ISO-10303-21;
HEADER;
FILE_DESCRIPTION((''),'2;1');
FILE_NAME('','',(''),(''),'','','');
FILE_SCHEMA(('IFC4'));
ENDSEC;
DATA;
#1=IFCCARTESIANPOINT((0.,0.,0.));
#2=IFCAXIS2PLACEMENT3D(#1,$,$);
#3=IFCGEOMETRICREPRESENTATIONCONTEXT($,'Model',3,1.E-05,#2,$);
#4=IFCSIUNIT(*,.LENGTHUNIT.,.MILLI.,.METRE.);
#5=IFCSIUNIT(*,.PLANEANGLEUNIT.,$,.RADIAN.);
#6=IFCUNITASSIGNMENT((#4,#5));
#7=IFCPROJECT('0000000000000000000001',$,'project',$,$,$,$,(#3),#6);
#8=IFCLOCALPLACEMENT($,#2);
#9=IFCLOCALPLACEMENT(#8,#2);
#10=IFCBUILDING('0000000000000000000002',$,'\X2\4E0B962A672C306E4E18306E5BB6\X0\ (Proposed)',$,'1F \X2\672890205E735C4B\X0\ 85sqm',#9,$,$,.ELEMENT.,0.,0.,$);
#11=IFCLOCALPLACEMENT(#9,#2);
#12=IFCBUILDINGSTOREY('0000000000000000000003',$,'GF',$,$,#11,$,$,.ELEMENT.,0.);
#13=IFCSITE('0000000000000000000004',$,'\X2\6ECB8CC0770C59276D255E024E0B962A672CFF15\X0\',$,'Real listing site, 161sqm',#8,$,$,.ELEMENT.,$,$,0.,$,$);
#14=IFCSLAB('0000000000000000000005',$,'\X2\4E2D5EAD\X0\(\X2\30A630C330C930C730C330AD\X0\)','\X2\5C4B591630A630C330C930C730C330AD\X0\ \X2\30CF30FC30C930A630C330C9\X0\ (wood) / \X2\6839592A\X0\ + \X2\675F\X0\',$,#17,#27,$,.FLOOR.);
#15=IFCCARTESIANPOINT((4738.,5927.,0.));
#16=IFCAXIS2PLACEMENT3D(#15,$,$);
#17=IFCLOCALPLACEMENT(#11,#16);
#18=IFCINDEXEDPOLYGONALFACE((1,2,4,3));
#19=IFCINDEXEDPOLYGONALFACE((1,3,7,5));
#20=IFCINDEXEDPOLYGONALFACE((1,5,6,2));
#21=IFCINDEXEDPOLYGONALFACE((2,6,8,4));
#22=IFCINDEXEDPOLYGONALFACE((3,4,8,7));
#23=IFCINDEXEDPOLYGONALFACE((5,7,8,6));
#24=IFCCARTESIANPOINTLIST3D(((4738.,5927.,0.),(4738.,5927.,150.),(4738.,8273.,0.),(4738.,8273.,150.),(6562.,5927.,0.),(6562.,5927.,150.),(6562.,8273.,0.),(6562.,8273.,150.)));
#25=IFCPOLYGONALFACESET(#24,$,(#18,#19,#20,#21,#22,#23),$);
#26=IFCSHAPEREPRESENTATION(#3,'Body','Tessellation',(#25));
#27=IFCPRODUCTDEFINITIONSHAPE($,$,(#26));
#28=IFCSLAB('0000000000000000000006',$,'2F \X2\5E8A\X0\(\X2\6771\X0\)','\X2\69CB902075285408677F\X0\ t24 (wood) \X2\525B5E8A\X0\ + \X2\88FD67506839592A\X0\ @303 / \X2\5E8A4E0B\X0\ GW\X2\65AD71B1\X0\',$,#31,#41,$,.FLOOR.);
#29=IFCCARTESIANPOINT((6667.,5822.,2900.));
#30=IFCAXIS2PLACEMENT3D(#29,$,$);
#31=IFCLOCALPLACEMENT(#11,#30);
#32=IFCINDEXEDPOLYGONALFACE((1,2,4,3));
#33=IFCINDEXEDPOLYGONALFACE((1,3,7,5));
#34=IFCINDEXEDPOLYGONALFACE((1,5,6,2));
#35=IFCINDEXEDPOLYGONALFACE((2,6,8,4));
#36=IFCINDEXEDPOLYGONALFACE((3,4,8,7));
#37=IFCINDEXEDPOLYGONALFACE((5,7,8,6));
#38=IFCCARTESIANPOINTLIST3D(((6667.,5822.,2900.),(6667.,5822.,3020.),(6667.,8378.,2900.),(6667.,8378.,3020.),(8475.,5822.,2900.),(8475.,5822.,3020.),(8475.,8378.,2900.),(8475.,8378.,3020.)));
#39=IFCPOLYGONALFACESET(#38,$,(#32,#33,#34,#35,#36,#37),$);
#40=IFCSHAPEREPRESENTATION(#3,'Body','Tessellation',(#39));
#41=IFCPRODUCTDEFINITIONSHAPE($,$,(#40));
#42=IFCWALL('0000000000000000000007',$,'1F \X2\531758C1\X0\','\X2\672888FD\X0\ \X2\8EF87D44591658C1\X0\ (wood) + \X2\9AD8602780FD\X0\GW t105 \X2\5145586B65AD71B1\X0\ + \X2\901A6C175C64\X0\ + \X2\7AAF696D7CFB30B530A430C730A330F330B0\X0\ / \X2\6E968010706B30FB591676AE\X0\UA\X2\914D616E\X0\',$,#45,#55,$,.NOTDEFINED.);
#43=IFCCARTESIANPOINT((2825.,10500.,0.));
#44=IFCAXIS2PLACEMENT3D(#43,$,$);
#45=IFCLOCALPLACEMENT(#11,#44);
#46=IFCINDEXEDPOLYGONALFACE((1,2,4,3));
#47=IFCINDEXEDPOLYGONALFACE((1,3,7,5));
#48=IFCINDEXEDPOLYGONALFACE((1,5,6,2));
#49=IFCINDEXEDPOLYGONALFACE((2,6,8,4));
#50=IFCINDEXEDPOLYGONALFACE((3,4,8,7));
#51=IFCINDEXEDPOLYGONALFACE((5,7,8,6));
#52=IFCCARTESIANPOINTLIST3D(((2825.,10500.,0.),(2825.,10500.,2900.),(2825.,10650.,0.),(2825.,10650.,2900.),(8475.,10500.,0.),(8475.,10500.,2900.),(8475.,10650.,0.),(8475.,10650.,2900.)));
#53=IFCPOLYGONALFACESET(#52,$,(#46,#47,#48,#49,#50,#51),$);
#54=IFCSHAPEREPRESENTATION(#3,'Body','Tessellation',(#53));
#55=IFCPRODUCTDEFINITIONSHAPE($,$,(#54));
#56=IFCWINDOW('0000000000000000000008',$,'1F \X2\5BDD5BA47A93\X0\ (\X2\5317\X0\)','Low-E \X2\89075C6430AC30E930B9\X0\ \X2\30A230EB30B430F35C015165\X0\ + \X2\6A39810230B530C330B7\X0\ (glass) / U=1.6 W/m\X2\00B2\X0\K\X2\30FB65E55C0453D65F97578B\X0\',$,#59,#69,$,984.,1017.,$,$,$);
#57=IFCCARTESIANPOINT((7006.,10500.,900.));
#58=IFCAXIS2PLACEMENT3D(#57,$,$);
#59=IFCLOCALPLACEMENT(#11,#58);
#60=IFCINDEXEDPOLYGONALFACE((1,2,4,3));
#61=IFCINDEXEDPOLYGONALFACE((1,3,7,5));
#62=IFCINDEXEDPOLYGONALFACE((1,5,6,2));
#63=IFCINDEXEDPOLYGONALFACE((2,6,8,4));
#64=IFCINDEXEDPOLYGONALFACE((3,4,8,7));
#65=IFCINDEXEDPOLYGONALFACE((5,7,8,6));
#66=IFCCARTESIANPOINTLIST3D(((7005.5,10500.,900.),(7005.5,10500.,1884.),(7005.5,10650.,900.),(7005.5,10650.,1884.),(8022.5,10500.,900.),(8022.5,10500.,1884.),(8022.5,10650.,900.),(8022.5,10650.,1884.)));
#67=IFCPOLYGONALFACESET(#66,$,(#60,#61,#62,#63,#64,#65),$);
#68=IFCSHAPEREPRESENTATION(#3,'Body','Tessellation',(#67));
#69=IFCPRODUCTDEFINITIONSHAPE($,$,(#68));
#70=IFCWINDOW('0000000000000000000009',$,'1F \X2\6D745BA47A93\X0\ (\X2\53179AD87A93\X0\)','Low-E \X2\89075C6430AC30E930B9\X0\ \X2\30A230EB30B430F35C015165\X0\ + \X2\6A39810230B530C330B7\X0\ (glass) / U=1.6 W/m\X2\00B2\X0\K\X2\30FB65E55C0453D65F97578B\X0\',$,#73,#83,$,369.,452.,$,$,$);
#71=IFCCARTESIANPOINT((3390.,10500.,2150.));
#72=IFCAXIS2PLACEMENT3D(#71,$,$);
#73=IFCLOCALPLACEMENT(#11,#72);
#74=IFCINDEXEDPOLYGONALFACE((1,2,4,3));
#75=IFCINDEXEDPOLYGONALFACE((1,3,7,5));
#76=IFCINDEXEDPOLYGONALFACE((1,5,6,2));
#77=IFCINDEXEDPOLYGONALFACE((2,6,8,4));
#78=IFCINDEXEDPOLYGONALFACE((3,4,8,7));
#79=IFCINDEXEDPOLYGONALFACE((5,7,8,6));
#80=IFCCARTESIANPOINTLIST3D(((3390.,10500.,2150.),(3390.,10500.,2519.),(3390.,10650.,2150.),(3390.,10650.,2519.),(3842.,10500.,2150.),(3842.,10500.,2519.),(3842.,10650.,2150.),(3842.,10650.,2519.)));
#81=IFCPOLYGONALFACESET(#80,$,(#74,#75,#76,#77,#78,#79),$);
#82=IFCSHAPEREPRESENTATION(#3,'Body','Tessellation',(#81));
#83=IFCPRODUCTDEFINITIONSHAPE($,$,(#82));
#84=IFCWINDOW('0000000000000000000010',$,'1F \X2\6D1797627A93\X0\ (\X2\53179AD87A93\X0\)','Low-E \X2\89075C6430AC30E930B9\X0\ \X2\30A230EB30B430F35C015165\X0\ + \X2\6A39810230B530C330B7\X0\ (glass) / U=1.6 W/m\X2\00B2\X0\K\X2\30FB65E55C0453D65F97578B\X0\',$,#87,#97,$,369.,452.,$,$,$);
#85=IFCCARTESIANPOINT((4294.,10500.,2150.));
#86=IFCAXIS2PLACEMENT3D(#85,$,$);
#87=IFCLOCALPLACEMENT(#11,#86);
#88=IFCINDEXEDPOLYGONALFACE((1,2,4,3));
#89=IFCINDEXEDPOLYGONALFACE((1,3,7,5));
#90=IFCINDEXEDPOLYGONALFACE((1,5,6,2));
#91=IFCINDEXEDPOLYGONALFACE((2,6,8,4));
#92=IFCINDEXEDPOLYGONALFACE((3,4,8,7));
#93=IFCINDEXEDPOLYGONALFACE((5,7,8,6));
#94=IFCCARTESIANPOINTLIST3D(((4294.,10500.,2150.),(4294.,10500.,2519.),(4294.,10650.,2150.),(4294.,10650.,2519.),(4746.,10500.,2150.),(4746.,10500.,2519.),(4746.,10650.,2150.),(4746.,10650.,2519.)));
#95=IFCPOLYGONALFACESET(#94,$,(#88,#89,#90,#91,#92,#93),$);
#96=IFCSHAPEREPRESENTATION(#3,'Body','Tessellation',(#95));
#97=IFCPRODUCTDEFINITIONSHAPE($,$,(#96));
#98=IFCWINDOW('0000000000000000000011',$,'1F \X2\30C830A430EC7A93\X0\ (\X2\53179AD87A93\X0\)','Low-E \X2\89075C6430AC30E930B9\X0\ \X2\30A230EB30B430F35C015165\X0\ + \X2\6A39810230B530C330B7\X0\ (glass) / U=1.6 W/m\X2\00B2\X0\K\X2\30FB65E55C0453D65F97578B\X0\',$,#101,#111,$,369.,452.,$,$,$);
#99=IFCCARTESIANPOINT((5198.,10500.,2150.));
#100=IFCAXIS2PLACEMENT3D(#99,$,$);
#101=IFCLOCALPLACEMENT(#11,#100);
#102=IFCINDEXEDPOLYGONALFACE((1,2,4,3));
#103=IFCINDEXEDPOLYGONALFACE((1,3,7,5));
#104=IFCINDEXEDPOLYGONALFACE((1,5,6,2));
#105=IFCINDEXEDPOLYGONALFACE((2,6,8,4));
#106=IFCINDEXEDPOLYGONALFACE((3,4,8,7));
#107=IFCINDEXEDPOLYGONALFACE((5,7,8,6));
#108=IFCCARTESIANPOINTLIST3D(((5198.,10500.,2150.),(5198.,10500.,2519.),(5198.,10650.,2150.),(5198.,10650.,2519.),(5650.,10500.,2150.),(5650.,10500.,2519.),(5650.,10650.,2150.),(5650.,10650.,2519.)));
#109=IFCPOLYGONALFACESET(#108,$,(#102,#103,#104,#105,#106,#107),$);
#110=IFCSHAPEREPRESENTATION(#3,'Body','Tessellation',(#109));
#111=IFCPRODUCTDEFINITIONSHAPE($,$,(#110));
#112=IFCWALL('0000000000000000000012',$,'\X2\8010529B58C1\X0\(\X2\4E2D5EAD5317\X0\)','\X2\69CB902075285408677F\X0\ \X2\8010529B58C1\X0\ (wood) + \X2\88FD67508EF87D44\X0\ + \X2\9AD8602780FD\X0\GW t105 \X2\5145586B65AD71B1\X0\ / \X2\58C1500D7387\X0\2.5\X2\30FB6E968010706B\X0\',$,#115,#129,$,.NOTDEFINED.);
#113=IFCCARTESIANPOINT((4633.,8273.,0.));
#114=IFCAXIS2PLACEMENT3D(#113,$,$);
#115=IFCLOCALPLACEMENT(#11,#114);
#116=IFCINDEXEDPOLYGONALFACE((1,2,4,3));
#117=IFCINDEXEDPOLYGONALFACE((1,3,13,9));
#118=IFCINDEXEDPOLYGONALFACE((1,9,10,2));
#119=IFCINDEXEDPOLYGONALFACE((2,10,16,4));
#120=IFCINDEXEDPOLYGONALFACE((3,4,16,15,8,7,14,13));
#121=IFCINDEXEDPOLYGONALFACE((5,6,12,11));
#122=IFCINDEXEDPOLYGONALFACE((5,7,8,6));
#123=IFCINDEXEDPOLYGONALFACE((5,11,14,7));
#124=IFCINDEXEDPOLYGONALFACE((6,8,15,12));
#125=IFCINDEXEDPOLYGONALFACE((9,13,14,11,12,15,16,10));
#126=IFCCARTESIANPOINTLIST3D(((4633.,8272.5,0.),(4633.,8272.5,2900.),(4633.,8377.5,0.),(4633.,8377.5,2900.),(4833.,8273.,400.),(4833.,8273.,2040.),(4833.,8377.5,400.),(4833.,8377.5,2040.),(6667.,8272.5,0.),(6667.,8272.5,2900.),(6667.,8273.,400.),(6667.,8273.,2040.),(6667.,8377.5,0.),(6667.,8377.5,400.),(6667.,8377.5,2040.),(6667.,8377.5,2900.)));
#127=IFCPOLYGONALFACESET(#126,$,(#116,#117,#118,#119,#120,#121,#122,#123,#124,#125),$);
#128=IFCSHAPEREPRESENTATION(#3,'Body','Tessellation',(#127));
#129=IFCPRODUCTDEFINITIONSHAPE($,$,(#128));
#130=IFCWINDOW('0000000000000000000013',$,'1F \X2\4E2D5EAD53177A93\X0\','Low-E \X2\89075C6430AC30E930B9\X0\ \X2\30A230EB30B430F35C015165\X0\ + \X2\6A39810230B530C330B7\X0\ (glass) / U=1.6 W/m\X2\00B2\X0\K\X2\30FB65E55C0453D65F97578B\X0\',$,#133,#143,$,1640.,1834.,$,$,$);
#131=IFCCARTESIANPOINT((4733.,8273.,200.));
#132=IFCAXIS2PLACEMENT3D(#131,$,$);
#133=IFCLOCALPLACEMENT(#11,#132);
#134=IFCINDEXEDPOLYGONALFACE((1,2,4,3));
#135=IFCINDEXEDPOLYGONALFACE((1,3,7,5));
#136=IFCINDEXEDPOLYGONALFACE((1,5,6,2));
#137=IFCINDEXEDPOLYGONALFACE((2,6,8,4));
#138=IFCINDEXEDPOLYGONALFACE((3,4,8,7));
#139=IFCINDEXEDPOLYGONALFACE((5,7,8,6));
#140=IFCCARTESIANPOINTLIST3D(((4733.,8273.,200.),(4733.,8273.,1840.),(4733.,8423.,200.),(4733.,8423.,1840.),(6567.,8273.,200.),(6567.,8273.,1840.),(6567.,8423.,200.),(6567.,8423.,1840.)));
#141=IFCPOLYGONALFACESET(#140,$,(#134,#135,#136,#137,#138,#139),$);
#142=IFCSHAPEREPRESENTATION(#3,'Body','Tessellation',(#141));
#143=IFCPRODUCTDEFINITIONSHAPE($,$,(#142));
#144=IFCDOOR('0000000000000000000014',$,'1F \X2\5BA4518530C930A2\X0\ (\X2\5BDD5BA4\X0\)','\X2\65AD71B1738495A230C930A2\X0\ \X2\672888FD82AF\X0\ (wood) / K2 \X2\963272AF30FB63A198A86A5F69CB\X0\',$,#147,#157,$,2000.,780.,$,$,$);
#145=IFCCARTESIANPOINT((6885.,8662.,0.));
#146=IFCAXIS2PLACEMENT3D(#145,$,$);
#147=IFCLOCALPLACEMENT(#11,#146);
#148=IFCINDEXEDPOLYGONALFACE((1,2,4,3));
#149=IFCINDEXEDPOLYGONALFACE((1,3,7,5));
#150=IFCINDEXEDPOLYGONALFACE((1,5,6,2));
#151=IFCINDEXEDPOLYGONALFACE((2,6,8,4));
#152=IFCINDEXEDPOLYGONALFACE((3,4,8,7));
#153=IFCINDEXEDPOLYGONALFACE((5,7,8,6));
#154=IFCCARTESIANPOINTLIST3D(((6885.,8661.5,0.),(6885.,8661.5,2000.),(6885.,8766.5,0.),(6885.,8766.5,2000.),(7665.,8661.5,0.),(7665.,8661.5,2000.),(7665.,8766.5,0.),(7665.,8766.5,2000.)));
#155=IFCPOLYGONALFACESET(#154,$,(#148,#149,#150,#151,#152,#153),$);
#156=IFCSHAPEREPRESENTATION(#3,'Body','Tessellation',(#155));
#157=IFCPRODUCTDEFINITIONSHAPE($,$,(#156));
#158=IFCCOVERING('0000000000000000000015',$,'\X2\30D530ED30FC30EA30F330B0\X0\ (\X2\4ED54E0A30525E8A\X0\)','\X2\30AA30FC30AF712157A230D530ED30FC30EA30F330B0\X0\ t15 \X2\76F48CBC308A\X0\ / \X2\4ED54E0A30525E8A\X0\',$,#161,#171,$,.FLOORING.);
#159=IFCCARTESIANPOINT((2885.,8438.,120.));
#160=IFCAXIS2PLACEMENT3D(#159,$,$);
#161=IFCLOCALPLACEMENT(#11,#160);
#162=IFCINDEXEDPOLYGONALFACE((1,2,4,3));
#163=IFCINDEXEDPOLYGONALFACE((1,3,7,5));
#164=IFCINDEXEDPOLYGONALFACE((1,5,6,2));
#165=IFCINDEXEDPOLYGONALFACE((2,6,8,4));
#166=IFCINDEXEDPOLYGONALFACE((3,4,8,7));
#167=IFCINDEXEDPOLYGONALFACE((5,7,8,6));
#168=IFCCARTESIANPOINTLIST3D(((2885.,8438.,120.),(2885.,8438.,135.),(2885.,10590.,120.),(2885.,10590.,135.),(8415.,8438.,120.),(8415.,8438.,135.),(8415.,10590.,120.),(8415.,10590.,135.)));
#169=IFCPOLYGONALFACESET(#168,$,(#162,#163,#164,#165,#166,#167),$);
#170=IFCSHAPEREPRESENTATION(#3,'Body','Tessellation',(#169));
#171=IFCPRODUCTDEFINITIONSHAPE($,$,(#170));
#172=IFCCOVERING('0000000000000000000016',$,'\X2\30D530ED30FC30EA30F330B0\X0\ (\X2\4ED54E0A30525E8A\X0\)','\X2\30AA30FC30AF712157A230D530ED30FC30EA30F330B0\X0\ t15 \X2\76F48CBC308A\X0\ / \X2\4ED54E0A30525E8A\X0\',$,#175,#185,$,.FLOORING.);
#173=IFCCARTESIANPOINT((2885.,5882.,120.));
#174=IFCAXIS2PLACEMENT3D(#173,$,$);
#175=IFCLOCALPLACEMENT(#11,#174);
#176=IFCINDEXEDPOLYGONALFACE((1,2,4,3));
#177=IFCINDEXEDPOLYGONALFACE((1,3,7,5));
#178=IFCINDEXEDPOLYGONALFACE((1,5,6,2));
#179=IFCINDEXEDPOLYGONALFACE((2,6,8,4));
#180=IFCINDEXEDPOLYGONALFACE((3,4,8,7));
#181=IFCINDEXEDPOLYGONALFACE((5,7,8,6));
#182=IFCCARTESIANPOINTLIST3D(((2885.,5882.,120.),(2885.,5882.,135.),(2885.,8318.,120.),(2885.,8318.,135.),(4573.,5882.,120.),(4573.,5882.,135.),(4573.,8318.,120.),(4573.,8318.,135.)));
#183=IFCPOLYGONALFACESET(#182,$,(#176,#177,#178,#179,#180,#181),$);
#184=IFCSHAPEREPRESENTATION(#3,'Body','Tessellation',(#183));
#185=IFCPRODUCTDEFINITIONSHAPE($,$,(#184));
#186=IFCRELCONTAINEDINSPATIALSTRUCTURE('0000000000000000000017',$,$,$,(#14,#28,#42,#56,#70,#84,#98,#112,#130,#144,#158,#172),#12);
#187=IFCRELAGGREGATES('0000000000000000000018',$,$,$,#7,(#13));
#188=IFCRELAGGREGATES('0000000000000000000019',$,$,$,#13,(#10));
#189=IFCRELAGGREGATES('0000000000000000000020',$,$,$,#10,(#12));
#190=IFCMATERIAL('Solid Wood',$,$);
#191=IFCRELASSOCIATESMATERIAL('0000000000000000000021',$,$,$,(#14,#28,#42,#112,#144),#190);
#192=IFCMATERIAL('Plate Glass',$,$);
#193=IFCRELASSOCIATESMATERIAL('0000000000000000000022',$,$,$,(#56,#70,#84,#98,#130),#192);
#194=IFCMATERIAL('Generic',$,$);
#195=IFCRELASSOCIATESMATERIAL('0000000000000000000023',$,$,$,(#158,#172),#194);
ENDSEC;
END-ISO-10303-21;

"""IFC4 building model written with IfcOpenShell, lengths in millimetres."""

from ifc_helpers import new_model, si_unit, frame, frame_2d, origin, place, context, project, spatial, rectangle, extrude, material, element, fill, save


model = new_model("IFC4")

# Units and contexts
model_context = context("Model", 3, precision=1e-05, world=origin())
ifc_project = project(units=[si_unit("LENGTHUNIT", "METRE", prefix="MILLI"), si_unit("PLANEANGLEUNIT", "RADIAN")], contexts=[model_context])

# Site, building, storey
site_placement = place(None, origin())
site = spatial("IfcSite", under=ifc_project, at=site_placement, Name="滋賀県大津市下阪本５", ObjectType="Real listing site, 161sqm", CompositionType="ELEMENT", RefElevation=0.0)
building_placement = place(site_placement, origin())
building = spatial("IfcBuilding", under=site, at=building_placement, Name="下阪本の丘の家 (Proposed)", ObjectType="1F 木造平屋 85sqm", CompositionType="ELEMENT", ElevationOfRefHeight=0.0, ElevationOfTerrain=0.0)
storey_placement = place(building_placement, origin())
storey = spatial("IfcBuildingStorey", under=building, at=storey_placement, Name="GF", CompositionType="ELEMENT", Elevation=0.0)

# Slabs
ifc_material_1 = material(Name="Solid Wood")
slab_1_placement = place(storey_placement, frame((4738.0, 5927.0, 0.0)))
element("IfcSlab", 1, at=slab_1_placement, inside=storey, material=ifc_material_1, Name="中庭(ウッドデッキ)", Description="屋外ウッドデッキ ハードウッド (wood) / 根太 + 束", PredefinedType="FLOOR", context=model_context, shape_type="SweptSolid", body=[
    extrude(rectangle(XDim=1824.0, YDim=2346.0, at=frame_2d((912.0, 1173.0))), frame((4738.0, 5927.0, 0.0)), (0.0, 0.0, 1.0), 150.0),
])
slab_2_placement = place(storey_placement, frame((6667.0, 5822.0, 2900.0)))
element("IfcSlab", 2, at=slab_2_placement, inside=storey, material=ifc_material_1, Name="2F 床(東)", Description="構造用合板 t24 (wood) 剛床 + 製材根太 @303 / 床下 GW断熱", PredefinedType="FLOOR", context=model_context, shape_type="SweptSolid", body=[
    extrude(rectangle(XDim=1808.0, YDim=2556.0, at=frame_2d((904.0, 1278.0))), frame((6667.0, 5822.0, 2900.0)), (0.0, 0.0, 1.0), 120.0),
])

# Wall, openings, windows
wall_1_placement = place(storey_placement, frame((2825.0, 10500.0, 0.0)))
wall_1 = element("IfcWall", 3, at=wall_1_placement, inside=storey, material=ifc_material_1, Name="1F 北壁", Description="木製 軸組外壁 (wood) + 高性能GW t105 充填断熱 + 通気層 + 窯業系サイディング / 準耐火・外皮UA配慮", PredefinedType="NOTDEFINED", context=model_context, shape_type="SweptSolid", body=[
    extrude(rectangle(XDim=5650.0, YDim=150.0, at=frame_2d((2825.0, 75.0))), frame((2825.0, 10500.0, 0.0)), (0.0, 0.0, 1.0), 2900.0),
])
opening_1_placement = place(storey_placement, frame((7006.0, 10500.0, 900.0)))
opening_1 = element("IfcOpeningElement", 4, at=opening_1_placement, cuts=wall_1, PredefinedType="NOTDEFINED", context=model_context, shape_type="SweptSolid", body=[
    extrude(rectangle(XDim=1017.0, YDim=150.0, at=frame_2d((508.0, 75.0))), frame((7006.0, 10500.0, 900.0)), (0.0, 0.0, 1.0), 984.0),
])
opening_2_placement = place(storey_placement, frame((3390.0, 10500.0, 2150.0)))
opening_2 = element("IfcOpeningElement", 5, at=opening_2_placement, cuts=wall_1, PredefinedType="NOTDEFINED", context=model_context, shape_type="SweptSolid", body=[
    extrude(rectangle(XDim=452.0, YDim=150.0, at=frame_2d((226.0, 75.0))), frame((3390.0, 10500.0, 2150.0)), (0.0, 0.0, 1.0), 369.0),
])
opening_3_placement = place(storey_placement, frame((4294.0, 10500.0, 2150.0)))
opening_3 = element("IfcOpeningElement", 6, at=opening_3_placement, cuts=wall_1, PredefinedType="NOTDEFINED", context=model_context, shape_type="SweptSolid", body=[
    extrude(rectangle(XDim=452.0, YDim=150.0, at=frame_2d((226.0, 75.0))), frame((4294.0, 10500.0, 2150.0)), (0.0, 0.0, 1.0), 369.0),
])
opening_4_placement = place(storey_placement, frame((5198.0, 10500.0, 2150.0)))
opening_4 = element("IfcOpeningElement", 7, at=opening_4_placement, cuts=wall_1, PredefinedType="NOTDEFINED", context=model_context, shape_type="SweptSolid", body=[
    extrude(rectangle(XDim=452.0, YDim=150.0, at=frame_2d((226.0, 75.0))), frame((5198.0, 10500.0, 2150.0)), (0.0, 0.0, 1.0), 369.0),
])
ifc_material_2 = material(Name="Plate Glass")
window_1_placement = place(storey_placement, frame((7006.0, 10500.0, 900.0)))
window_1 = element("IfcWindow", 8, at=window_1_placement, inside=storey, material=ifc_material_2, Name="1F 寝室窓 (北)", Description="Low-E 複層ガラス アルゴン封入 + 樹脂サッシ (glass) / U=1.6 W/m²K・日射取得型", OverallHeight=984.0, OverallWidth=1017.0, context=model_context, shape_type="SweptSolid", body=[
    extrude(rectangle(XDim=1017.0, YDim=150.0, at=frame_2d((508.0, 75.0))), frame((7006.0, 10500.0, 900.0)), (0.0, 0.0, 1.0), 984.0),
])
fill(opening_1, window_1)
window_2_placement = place(storey_placement, frame((3390.0, 10500.0, 2150.0)))
window_2 = element("IfcWindow", 9, at=window_2_placement, inside=storey, material=ifc_material_2, Name="1F 浴室窓 (北高窓)", Description="Low-E 複層ガラス アルゴン封入 + 樹脂サッシ (glass) / U=1.6 W/m²K・日射取得型", OverallHeight=369.0, OverallWidth=452.0, context=model_context, shape_type="SweptSolid", body=[
    extrude(rectangle(XDim=452.0, YDim=150.0, at=frame_2d((226.0, 75.0))), frame((3390.0, 10500.0, 2150.0)), (0.0, 0.0, 1.0), 369.0),
])
fill(opening_2, window_2)
window_3_placement = place(storey_placement, frame((4294.0, 10500.0, 2150.0)))
window_3 = element("IfcWindow", 10, at=window_3_placement, inside=storey, material=ifc_material_2, Name="1F 洗面窓 (北高窓)", Description="Low-E 複層ガラス アルゴン封入 + 樹脂サッシ (glass) / U=1.6 W/m²K・日射取得型", OverallHeight=369.0, OverallWidth=452.0, context=model_context, shape_type="SweptSolid", body=[
    extrude(rectangle(XDim=452.0, YDim=150.0, at=frame_2d((226.0, 75.0))), frame((4294.0, 10500.0, 2150.0)), (0.0, 0.0, 1.0), 369.0),
])
fill(opening_3, window_3)
window_4_placement = place(storey_placement, frame((5198.0, 10500.0, 2150.0)))
window_4 = element("IfcWindow", 11, at=window_4_placement, inside=storey, material=ifc_material_2, Name="1F トイレ窓 (北高窓)", Description="Low-E 複層ガラス アルゴン封入 + 樹脂サッシ (glass) / U=1.6 W/m²K・日射取得型", OverallHeight=369.0, OverallWidth=452.0, context=model_context, shape_type="SweptSolid", body=[
    extrude(rectangle(XDim=452.0, YDim=150.0, at=frame_2d((226.0, 75.0))), frame((5198.0, 10500.0, 2150.0)), (0.0, 0.0, 1.0), 369.0),
])
fill(opening_4, window_4)

# Wall, opening, window
wall_2_placement = place(storey_placement, frame((4633.0, 8273.0, 0.0)))
wall_2 = element("IfcWall", 12, at=wall_2_placement, inside=storey, material=ifc_material_1, Name="耐力壁(中庭北)", Description="構造用合板 耐力壁 (wood) + 製材軸組 + 高性能GW t105 充填断熱 / 壁倍率2.5・準耐火", PredefinedType="NOTDEFINED", context=model_context, shape_type="SweptSolid", body=[
    extrude(rectangle(XDim=2034.0, YDim=105.0, at=frame_2d((1017.0, 52.0))), frame((4633.0, 8273.0, 0.0)), (0.0, 0.0, 1.0), 2900.0),
])
opening_5_placement = place(storey_placement, frame((4733.0, 8273.0, 200.0)))
opening_5 = element("IfcOpeningElement", 13, at=opening_5_placement, cuts=wall_2, PredefinedType="NOTDEFINED", context=model_context, shape_type="SweptSolid", body=[
    extrude(rectangle(XDim=1834.0, YDim=150.0, at=frame_2d((917.0, 75.0))), frame((4733.0, 8273.0, 200.0)), (0.0, 0.0, 1.0), 1640.0),
])
window_5_placement = place(storey_placement, frame((4733.0, 8273.0, 200.0)))
window_5 = element("IfcWindow", 14, at=window_5_placement, inside=storey, material=ifc_material_2, Name="1F 中庭北窓", Description="Low-E 複層ガラス アルゴン封入 + 樹脂サッシ (glass) / U=1.6 W/m²K・日射取得型", OverallHeight=1640.0, OverallWidth=1834.0, context=model_context, shape_type="SweptSolid", body=[
    extrude(rectangle(XDim=1834.0, YDim=150.0, at=frame_2d((917.0, 75.0))), frame((4733.0, 8273.0, 200.0)), (0.0, 0.0, 1.0), 1640.0),
])
fill(opening_5, window_5)

# Door
door_1_placement = place(storey_placement, frame((6885.0, 8662.0, 0.0)))
element("IfcDoor", 15, at=door_1_placement, inside=storey, material=ifc_material_1, Name="1F 室内ドア (寝室)", Description="断熱玄関ドア 木製芯 (wood) / K2 防犯・採風機構", OverallHeight=2000.0, OverallWidth=780.0, context=model_context, shape_type="SweptSolid", body=[
    extrude(rectangle(XDim=780.0, YDim=105.0, at=frame_2d((390.0, 52.0))), frame((6885.0, 8662.0, 0.0)), (0.0, 0.0, 1.0), 2000.0),
])

# Coverings
ifc_material_3 = material(Name="Generic")
covering_1_placement = place(storey_placement, frame((2885.0, 8438.0, 120.0)))
element("IfcCovering", 16, at=covering_1_placement, inside=storey, material=ifc_material_3, Name="フローリング (仕上げ床)", Description="オーク無垢フローリング t15 直貼り / 仕上げ床", PredefinedType="FLOORING", context=model_context, shape_type="SweptSolid", body=[
    extrude(rectangle(XDim=5530.0, YDim=2152.0, at=frame_2d((2765.0, 1076.0))), frame((2885.0, 8438.0, 120.0)), (0.0, 0.0, 1.0), 15.0),
])
covering_2_placement = place(storey_placement, frame((2885.0, 5882.0, 120.0)))
element("IfcCovering", 17, at=covering_2_placement, inside=storey, material=ifc_material_3, Name="フローリング (仕上げ床)", Description="オーク無垢フローリング t15 直貼り / 仕上げ床", PredefinedType="FLOORING", context=model_context, shape_type="SweptSolid", body=[
    extrude(rectangle(XDim=1688.0, YDim=2436.0, at=frame_2d((844.0, 1218.0))), frame((2885.0, 5882.0, 120.0)), (0.0, 0.0, 1.0), 15.0),
])

save(model, "model.ifc")
